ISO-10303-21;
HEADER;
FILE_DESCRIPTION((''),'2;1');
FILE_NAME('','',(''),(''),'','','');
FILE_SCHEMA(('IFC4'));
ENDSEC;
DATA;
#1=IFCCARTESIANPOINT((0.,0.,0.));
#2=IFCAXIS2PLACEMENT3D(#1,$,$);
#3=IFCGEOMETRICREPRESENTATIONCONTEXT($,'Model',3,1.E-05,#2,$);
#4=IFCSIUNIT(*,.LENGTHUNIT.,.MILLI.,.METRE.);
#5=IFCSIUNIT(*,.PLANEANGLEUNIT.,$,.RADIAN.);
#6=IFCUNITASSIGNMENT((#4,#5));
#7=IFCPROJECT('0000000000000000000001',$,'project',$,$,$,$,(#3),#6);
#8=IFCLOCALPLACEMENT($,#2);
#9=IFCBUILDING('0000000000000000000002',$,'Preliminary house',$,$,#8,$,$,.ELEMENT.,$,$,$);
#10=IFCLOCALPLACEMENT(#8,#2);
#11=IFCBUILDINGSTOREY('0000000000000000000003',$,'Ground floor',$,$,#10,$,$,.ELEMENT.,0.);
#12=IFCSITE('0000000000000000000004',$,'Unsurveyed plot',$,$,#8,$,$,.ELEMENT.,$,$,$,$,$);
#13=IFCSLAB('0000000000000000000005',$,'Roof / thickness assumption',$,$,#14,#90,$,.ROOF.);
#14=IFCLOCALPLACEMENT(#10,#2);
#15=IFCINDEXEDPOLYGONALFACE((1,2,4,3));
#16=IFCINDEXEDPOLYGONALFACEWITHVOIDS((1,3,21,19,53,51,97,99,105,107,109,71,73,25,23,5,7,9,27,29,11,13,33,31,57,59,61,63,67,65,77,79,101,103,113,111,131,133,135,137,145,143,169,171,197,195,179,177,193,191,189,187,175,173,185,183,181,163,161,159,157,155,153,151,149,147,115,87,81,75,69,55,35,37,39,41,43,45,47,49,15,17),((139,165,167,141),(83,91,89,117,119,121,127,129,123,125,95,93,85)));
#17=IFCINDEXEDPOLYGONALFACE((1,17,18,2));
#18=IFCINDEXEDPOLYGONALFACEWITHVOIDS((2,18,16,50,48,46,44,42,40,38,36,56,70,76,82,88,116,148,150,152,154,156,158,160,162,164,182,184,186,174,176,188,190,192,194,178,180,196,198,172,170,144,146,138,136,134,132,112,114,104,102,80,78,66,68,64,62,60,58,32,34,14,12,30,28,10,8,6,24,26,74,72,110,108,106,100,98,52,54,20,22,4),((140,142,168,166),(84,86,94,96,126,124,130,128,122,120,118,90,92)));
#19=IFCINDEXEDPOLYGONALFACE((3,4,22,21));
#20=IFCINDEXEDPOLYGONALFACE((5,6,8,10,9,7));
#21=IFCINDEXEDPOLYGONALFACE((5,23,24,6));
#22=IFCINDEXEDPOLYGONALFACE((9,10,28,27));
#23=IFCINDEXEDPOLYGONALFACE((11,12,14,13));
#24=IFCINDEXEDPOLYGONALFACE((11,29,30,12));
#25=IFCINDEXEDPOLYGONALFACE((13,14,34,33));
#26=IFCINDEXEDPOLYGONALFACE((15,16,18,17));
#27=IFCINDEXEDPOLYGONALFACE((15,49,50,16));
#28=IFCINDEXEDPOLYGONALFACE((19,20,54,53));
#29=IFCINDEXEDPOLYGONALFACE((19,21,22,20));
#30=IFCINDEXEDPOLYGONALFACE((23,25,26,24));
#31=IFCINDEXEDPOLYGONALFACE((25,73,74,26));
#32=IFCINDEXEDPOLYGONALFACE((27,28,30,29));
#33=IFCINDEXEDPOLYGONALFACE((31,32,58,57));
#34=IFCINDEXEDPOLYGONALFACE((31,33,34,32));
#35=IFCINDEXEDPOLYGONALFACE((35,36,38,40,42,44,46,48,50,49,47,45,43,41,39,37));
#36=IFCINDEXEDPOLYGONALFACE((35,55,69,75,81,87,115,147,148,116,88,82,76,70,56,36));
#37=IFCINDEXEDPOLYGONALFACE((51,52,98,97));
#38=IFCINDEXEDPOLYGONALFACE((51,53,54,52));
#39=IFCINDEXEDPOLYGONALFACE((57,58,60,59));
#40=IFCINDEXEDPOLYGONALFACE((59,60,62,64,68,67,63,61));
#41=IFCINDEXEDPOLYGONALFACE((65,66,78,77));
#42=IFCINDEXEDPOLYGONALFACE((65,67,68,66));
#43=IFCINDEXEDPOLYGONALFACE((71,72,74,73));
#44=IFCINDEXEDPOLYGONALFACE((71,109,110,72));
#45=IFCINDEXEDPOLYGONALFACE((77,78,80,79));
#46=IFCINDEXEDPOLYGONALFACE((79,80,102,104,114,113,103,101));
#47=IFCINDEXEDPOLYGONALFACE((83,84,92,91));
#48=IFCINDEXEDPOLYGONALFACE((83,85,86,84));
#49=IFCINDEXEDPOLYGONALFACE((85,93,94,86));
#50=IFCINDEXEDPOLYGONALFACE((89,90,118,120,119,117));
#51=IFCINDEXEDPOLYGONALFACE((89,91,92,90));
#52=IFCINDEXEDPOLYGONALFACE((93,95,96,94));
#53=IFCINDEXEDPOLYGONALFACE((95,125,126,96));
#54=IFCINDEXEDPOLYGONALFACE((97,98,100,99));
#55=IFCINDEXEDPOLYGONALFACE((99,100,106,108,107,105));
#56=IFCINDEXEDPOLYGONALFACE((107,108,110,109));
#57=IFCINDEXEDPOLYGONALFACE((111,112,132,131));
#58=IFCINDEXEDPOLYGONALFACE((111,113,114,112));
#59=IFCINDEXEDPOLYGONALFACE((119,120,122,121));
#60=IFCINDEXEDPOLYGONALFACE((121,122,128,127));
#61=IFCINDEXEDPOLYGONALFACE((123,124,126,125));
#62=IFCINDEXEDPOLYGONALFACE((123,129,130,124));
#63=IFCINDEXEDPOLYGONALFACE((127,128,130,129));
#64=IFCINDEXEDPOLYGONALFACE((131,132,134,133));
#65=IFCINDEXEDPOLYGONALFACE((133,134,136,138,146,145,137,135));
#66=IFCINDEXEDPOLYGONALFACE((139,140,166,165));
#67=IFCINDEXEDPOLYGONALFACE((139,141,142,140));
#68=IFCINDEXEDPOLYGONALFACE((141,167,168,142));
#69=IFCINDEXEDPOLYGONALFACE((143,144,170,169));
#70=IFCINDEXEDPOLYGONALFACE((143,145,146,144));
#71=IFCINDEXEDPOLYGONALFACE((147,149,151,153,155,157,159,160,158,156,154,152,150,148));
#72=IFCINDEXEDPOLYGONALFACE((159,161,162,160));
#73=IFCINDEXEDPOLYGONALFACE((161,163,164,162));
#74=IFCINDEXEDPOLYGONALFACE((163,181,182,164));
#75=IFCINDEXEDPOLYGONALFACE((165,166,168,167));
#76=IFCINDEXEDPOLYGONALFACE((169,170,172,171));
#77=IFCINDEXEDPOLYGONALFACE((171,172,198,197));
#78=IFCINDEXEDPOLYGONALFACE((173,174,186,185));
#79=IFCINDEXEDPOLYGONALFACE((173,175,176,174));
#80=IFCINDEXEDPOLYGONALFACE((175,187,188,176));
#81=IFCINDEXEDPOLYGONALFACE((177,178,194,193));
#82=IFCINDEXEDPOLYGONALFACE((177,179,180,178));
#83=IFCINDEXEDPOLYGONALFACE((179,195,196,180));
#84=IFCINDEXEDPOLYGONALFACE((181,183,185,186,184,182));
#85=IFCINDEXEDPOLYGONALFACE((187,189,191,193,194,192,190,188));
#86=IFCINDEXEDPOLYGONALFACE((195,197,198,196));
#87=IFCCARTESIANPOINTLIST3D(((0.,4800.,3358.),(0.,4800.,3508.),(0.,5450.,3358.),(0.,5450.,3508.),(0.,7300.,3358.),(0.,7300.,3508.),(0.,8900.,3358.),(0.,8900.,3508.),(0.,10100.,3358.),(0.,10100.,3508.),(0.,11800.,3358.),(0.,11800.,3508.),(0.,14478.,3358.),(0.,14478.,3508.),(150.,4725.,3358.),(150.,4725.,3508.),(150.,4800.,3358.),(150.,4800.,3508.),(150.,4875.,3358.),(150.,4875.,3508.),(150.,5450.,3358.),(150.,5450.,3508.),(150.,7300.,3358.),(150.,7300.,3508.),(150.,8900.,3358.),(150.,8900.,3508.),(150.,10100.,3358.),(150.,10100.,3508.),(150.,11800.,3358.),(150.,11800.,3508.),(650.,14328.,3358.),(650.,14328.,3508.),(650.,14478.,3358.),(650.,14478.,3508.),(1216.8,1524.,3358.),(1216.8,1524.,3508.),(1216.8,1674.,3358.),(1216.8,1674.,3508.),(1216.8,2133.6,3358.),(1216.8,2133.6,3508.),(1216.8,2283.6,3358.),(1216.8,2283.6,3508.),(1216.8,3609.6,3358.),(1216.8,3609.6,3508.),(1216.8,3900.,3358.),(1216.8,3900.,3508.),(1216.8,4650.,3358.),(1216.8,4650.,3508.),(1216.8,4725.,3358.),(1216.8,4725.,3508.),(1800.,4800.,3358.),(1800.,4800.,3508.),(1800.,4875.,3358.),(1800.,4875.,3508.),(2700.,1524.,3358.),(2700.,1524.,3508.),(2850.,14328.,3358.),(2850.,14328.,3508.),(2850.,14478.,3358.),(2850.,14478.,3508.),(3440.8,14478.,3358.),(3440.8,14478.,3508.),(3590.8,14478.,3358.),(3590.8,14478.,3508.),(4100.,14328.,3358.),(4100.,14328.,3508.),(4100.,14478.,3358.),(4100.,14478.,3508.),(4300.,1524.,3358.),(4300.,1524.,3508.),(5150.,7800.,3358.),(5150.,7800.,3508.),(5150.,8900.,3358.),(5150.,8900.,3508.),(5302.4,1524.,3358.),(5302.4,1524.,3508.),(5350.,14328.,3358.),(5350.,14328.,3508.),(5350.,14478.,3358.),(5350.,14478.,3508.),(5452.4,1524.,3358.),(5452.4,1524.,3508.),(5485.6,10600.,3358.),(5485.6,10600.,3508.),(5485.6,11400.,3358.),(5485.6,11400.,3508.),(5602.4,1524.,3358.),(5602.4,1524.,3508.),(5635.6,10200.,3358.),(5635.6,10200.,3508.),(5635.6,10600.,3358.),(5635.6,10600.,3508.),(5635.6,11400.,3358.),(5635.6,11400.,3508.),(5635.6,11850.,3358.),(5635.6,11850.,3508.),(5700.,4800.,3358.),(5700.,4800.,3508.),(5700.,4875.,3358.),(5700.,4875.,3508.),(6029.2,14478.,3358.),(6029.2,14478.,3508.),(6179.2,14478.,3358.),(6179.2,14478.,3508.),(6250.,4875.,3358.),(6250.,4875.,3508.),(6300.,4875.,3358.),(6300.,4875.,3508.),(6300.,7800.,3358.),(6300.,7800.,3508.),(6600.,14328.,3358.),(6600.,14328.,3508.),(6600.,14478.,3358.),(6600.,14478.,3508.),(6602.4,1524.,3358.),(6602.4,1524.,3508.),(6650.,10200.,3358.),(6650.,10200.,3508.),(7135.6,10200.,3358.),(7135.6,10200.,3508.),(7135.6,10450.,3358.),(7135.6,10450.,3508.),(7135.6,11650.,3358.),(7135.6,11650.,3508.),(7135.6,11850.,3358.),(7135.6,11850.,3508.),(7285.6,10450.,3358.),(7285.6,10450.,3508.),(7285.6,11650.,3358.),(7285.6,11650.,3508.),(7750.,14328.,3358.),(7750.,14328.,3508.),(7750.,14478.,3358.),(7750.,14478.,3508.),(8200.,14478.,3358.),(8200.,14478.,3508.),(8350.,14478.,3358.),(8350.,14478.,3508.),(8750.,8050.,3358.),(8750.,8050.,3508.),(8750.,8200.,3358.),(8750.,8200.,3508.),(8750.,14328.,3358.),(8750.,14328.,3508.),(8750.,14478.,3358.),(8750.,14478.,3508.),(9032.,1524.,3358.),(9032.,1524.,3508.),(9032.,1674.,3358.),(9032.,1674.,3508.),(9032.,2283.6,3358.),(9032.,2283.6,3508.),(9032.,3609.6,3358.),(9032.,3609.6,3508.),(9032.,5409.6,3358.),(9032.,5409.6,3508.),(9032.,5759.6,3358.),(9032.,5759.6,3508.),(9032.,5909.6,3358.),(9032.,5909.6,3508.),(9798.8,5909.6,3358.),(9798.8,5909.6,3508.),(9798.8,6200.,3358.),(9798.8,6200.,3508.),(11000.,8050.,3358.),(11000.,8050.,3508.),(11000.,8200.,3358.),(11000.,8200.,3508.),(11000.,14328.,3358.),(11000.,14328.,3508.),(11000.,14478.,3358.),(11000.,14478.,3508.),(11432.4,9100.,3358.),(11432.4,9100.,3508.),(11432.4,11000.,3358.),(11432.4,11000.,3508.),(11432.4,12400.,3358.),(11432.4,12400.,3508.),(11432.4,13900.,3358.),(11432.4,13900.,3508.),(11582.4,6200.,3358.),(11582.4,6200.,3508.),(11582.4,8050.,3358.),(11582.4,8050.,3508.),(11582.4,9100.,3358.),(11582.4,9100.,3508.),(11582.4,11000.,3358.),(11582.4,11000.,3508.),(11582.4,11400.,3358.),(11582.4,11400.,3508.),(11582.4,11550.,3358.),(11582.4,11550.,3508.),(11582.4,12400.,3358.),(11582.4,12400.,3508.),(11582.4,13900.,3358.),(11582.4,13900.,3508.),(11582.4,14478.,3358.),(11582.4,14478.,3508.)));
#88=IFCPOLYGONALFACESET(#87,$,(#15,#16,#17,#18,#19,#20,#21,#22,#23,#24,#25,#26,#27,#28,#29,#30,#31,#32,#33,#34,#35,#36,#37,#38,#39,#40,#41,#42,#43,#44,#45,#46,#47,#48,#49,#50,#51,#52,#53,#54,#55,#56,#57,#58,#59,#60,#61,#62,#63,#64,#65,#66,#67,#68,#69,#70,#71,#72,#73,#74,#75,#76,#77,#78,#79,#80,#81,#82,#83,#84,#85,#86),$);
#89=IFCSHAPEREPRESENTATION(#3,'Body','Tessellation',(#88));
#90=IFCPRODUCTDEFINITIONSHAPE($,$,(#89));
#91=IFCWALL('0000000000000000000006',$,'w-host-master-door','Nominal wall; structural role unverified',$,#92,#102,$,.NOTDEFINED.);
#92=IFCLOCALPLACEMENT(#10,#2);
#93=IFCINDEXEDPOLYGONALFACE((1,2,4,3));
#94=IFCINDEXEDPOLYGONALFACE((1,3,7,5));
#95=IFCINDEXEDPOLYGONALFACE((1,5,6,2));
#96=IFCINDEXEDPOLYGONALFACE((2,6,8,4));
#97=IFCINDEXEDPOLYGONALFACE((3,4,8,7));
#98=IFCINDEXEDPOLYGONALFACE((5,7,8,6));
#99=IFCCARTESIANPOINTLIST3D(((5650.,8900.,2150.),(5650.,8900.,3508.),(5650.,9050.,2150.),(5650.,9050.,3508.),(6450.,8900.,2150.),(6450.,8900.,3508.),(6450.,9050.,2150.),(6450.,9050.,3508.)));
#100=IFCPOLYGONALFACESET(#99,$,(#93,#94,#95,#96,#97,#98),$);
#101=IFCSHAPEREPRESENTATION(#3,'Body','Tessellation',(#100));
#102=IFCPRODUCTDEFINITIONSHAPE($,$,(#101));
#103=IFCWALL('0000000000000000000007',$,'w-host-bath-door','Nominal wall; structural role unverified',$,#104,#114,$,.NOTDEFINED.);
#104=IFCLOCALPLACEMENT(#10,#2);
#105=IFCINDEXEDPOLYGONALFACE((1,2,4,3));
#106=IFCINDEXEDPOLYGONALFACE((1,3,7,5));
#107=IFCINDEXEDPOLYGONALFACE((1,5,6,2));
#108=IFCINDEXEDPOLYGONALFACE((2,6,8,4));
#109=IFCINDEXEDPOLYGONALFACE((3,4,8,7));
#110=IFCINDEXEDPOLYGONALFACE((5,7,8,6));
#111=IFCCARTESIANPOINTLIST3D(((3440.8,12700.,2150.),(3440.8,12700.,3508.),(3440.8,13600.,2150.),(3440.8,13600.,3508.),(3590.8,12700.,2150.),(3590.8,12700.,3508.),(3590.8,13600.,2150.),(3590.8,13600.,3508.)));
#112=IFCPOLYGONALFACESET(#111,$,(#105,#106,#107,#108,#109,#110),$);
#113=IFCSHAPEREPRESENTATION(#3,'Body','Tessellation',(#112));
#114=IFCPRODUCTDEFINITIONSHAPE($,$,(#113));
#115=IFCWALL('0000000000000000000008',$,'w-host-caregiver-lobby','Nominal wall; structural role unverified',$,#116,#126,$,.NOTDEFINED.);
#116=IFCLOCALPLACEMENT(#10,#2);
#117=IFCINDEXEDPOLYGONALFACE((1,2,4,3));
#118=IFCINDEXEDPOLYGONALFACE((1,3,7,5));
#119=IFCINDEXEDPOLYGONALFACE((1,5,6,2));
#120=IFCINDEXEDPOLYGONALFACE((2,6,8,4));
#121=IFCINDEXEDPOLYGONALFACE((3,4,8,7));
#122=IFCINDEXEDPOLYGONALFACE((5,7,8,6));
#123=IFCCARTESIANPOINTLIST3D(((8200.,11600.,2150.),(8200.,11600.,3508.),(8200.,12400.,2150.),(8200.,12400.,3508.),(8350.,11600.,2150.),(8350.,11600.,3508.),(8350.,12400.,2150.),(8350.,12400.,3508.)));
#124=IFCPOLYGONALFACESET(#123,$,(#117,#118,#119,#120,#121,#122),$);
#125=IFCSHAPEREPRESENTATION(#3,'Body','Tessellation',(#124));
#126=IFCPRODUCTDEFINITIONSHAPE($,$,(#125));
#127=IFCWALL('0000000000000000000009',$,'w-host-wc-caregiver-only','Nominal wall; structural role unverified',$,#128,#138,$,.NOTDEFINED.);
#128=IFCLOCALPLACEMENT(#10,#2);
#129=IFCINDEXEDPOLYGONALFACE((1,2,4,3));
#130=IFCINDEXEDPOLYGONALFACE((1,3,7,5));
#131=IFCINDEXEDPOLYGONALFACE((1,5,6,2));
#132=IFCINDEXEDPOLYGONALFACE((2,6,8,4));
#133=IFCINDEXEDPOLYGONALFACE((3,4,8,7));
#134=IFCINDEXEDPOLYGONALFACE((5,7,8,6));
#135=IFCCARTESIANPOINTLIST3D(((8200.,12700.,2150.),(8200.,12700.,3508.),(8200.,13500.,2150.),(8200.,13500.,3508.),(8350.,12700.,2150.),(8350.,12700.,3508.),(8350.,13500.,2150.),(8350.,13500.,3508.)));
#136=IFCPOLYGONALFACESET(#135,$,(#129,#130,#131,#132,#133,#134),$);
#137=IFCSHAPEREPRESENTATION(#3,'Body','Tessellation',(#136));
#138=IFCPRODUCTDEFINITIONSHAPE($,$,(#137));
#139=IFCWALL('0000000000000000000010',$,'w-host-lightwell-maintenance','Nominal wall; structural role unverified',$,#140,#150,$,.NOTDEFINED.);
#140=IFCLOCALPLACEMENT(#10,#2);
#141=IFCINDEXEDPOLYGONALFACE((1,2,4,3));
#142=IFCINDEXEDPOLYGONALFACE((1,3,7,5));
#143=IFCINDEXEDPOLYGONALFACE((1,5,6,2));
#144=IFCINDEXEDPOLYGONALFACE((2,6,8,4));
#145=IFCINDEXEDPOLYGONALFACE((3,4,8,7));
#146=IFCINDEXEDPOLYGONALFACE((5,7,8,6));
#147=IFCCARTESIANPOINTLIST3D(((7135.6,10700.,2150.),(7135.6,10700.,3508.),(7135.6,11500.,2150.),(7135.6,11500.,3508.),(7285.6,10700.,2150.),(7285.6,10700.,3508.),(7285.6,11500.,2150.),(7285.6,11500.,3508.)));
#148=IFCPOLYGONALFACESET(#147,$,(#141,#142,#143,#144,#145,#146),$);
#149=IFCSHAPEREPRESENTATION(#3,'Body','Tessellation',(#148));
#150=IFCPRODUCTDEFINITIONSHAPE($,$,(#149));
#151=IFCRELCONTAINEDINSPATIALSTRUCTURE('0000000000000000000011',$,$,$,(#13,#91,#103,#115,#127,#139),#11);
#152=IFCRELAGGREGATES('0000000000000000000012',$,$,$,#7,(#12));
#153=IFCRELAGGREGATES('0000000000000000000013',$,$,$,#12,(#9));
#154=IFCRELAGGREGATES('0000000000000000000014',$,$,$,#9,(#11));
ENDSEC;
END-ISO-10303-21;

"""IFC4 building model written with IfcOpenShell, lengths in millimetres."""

from ifc_helpers import new_model, si_unit, frame, origin, place, context, project, spatial, polyline, outline, extrude, element, save


model = new_model("IFC4")

# Units and contexts
model_context = context("Model", 3, precision=1e-05, world=origin())
ifc_project = project(units=[si_unit("LENGTHUNIT", "METRE", prefix="MILLI"), si_unit("PLANEANGLEUNIT", "RADIAN")], contexts=[model_context])

# Site, building, storey
placement_1 = place(None, origin())
site = spatial("IfcSite", under=ifc_project, at=placement_1, Name="Unsurveyed plot", CompositionType="ELEMENT")
building = spatial("IfcBuilding", under=site, at=placement_1, Name="Preliminary house", CompositionType="ELEMENT")
placement_2 = place(placement_1, origin())
storey = spatial("IfcBuildingStorey", under=building, at=placement_2, Name="Ground floor", CompositionType="ELEMENT", Elevation=0.0)

# Slab
element("IfcSlab", 1, at=placement_2, inside=storey, Name="Roof / thickness assumption", PredefinedType="ROOF", context=model_context, shape_type="SweptSolid", body=[
    extrude(outline(polyline([(6300.0, 4875.0), (6300.0, 7800.0), (5150.0, 7800.0), (5150.0, 8900.0), (150.0, 8900.0), (150.0, 7300.0), (0.0, 7300.0), (0.0, 8900.0), (0.0, 10100.0), (150.0, 10100.0), (150.0, 11800.0), (0.0, 11800.0), (0.0, 14478.0), (650.0, 14478.0), (650.0, 14328.0), (2850.0, 14328.0), (2850.0, 14478.0), (3440.8, 14478.0), (3590.8, 14478.0), (4100.0, 14478.0), (4100.0, 14328.0), (5350.0, 14328.0), (5350.0, 14478.0), (6029.2, 14478.0), (6179.2, 14478.0), (6600.0, 14478.0), (6600.0, 14328.0), (7750.0, 14328.0), (7750.0, 14478.0), (8200.0, 14478.0), (8350.0, 14478.0), (8750.0, 14478.0), (8750.0, 14328.0), (11000.0, 14328.0), (11000.0, 14478.0), (11582.4, 14478.0), (11582.4, 13900.0), (11432.4, 13900.0), (11432.4, 12400.0), (11582.4, 12400.0), (11582.4, 11550.0), (11582.4, 11400.0), (11582.4, 11000.0), (11432.4, 11000.0), (11432.4, 9100.0), (11582.4, 9100.0), (11582.4, 8050.0), (11582.4, 6200.0), (9798.8, 6200.0), (9798.8, 5909.6), (9032.0, 5909.6), (9032.0, 5759.6), (9032.0, 5409.6), (9032.0, 3609.6), (9032.0, 2283.6), (9032.0, 1674.0), (9032.0, 1524.0), (6602.4, 1524.0), (5602.4, 1524.0), (5452.4, 1524.0), (5302.4, 1524.0), (4300.0, 1524.0), (2700.0, 1524.0), (1216.8, 1524.0), (1216.8, 1674.0), (1216.8, 2133.6), (1216.8, 2283.6), (1216.8, 3609.6), (1216.8, 3900.0), (1216.8, 4650.0), (1216.8, 4725.0), (150.0, 4725.0), (150.0, 4800.0), (0.0, 4800.0), (0.0, 5450.0), (150.0, 5450.0), (150.0, 4875.0), (1800.0, 4875.0), (1800.0, 4800.0), (5700.0, 4800.0), (5700.0, 4875.0), (6250.0, 4875.0), (6300.0, 4875.0)]), holes=[polyline([(11000.0, 8050.0), (11000.0, 8200.0), (8750.0, 8200.0), (8750.0, 8050.0), (11000.0, 8050.0)]), polyline([(7135.6, 11650.0), (7135.6, 11850.0), (5635.6, 11850.0), (5635.6, 11400.0), (5485.6, 11400.0), (5485.6, 10600.0), (5635.6, 10600.0), (5635.6, 10200.0), (6650.0, 10200.0), (7135.6, 10200.0), (7135.6, 10450.0), (7285.6, 10450.0), (7285.6, 11650.0), (7135.6, 11650.0)])]), frame((0.0, 0.0, 3358.0)), (0.0, 0.0, 1.0), 150.0),
])

# Walls, openings
wall_1 = element("IfcWall", 2, at=placement_2, inside=storey, Name="w-host-master-door", Description="Nominal wall; structural role unverified", PredefinedType="NOTDEFINED", context=model_context, shape_type="SweptSolid", body=[
    extrude(outline(polyline([(5650.0, 8900.0), (6450.0, 8900.0), (6450.0, 9050.0), (5650.0, 9050.0), (5650.0, 8900.0)])), origin(), (0.0, 0.0, 1.0), 3508.0),
])
element("IfcOpeningElement", 3, at=placement_2, cuts=wall_1, PredefinedType="OPENING", context=model_context, shape_type="SweptSolid", body=[
    extrude(outline(polyline([(5650.0, 8525.0), (6450.0, 8525.0), (6450.0, 9425.0), (5650.0, 9425.0), (5650.0, 8525.0)])), origin(), (0.0, 0.0, 1.0), 2150.0),
])
wall_2 = element("IfcWall", 4, at=placement_2, inside=storey, Name="w-host-bath-door", Description="Nominal wall; structural role unverified", PredefinedType="NOTDEFINED", context=model_context, shape_type="SweptSolid", body=[
    extrude(outline(polyline([(3590.8, 12700.0), (3590.8, 13600.0), (3440.8, 13600.0), (3440.8, 12700.0), (3590.8, 12700.0)])), origin(), (0.0, 0.0, 1.0), 3508.0),
])
element("IfcOpeningElement", 5, at=placement_2, cuts=wall_2, PredefinedType="OPENING", context=model_context, shape_type="SweptSolid", body=[
    extrude(outline(polyline([(3965.8, 12700.0), (3965.8, 13600.0), (3065.8, 13600.0), (3065.8, 12700.0), (3965.8, 12700.0)])), origin(), (0.0, 0.0, 1.0), 2150.0),
])
wall_3 = element("IfcWall", 6, at=placement_2, inside=storey, Name="w-host-caregiver-lobby", Description="Nominal wall; structural role unverified", PredefinedType="NOTDEFINED", context=model_context, shape_type="SweptSolid", body=[
    extrude(outline(polyline([(8350.0, 11600.0), (8350.0, 12400.0), (8200.0, 12400.0), (8200.0, 11600.0), (8350.0, 11600.0)])), origin(), (0.0, 0.0, 1.0), 3508.0),
])
element("IfcOpeningElement", 7, at=placement_2, cuts=wall_3, PredefinedType="OPENING", context=model_context, shape_type="SweptSolid", body=[
    extrude(outline(polyline([(8725.0, 11600.0), (8725.0, 12400.0), (7825.0, 12400.0), (7825.0, 11600.0), (8725.0, 11600.0)])), origin(), (0.0, 0.0, 1.0), 2150.0),
])
wall_4 = element("IfcWall", 8, at=placement_2, inside=storey, Name="w-host-wc-caregiver-only", Description="Nominal wall; structural role unverified", PredefinedType="NOTDEFINED", context=model_context, shape_type="SweptSolid", body=[
    extrude(outline(polyline([(8350.0, 12700.0), (8350.0, 13500.0), (8200.0, 13500.0), (8200.0, 12700.0), (8350.0, 12700.0)])), origin(), (0.0, 0.0, 1.0), 3508.0),
])
element("IfcOpeningElement", 9, at=placement_2, cuts=wall_4, PredefinedType="OPENING", context=model_context, shape_type="SweptSolid", body=[
    extrude(outline(polyline([(8725.0, 12700.0), (8725.0, 13500.0), (7825.0, 13500.0), (7825.0, 12700.0), (8725.0, 12700.0)])), origin(), (0.0, 0.0, 1.0), 2150.0),
])
wall_5 = element("IfcWall", 10, at=placement_2, inside=storey, Name="w-host-lightwell-maintenance", Description="Nominal wall; structural role unverified", PredefinedType="NOTDEFINED", context=model_context, shape_type="SweptSolid", body=[
    extrude(outline(polyline([(7285.6, 10700.0), (7285.6, 11500.0), (7135.6, 11500.0), (7135.6, 10700.0), (7285.6, 10700.0)])), origin(), (0.0, 0.0, 1.0), 3508.0),
])
element("IfcOpeningElement", 11, at=placement_2, cuts=wall_5, PredefinedType="OPENING", context=model_context, shape_type="SweptSolid", body=[
    extrude(outline(polyline([(7660.6, 10700.0), (7660.6, 11500.0), (6760.6, 11500.0), (6760.6, 10700.0), (7660.6, 10700.0)])), origin(), (0.0, 0.0, 1.0), 2150.0),
])

save(model, "model.ifc")
